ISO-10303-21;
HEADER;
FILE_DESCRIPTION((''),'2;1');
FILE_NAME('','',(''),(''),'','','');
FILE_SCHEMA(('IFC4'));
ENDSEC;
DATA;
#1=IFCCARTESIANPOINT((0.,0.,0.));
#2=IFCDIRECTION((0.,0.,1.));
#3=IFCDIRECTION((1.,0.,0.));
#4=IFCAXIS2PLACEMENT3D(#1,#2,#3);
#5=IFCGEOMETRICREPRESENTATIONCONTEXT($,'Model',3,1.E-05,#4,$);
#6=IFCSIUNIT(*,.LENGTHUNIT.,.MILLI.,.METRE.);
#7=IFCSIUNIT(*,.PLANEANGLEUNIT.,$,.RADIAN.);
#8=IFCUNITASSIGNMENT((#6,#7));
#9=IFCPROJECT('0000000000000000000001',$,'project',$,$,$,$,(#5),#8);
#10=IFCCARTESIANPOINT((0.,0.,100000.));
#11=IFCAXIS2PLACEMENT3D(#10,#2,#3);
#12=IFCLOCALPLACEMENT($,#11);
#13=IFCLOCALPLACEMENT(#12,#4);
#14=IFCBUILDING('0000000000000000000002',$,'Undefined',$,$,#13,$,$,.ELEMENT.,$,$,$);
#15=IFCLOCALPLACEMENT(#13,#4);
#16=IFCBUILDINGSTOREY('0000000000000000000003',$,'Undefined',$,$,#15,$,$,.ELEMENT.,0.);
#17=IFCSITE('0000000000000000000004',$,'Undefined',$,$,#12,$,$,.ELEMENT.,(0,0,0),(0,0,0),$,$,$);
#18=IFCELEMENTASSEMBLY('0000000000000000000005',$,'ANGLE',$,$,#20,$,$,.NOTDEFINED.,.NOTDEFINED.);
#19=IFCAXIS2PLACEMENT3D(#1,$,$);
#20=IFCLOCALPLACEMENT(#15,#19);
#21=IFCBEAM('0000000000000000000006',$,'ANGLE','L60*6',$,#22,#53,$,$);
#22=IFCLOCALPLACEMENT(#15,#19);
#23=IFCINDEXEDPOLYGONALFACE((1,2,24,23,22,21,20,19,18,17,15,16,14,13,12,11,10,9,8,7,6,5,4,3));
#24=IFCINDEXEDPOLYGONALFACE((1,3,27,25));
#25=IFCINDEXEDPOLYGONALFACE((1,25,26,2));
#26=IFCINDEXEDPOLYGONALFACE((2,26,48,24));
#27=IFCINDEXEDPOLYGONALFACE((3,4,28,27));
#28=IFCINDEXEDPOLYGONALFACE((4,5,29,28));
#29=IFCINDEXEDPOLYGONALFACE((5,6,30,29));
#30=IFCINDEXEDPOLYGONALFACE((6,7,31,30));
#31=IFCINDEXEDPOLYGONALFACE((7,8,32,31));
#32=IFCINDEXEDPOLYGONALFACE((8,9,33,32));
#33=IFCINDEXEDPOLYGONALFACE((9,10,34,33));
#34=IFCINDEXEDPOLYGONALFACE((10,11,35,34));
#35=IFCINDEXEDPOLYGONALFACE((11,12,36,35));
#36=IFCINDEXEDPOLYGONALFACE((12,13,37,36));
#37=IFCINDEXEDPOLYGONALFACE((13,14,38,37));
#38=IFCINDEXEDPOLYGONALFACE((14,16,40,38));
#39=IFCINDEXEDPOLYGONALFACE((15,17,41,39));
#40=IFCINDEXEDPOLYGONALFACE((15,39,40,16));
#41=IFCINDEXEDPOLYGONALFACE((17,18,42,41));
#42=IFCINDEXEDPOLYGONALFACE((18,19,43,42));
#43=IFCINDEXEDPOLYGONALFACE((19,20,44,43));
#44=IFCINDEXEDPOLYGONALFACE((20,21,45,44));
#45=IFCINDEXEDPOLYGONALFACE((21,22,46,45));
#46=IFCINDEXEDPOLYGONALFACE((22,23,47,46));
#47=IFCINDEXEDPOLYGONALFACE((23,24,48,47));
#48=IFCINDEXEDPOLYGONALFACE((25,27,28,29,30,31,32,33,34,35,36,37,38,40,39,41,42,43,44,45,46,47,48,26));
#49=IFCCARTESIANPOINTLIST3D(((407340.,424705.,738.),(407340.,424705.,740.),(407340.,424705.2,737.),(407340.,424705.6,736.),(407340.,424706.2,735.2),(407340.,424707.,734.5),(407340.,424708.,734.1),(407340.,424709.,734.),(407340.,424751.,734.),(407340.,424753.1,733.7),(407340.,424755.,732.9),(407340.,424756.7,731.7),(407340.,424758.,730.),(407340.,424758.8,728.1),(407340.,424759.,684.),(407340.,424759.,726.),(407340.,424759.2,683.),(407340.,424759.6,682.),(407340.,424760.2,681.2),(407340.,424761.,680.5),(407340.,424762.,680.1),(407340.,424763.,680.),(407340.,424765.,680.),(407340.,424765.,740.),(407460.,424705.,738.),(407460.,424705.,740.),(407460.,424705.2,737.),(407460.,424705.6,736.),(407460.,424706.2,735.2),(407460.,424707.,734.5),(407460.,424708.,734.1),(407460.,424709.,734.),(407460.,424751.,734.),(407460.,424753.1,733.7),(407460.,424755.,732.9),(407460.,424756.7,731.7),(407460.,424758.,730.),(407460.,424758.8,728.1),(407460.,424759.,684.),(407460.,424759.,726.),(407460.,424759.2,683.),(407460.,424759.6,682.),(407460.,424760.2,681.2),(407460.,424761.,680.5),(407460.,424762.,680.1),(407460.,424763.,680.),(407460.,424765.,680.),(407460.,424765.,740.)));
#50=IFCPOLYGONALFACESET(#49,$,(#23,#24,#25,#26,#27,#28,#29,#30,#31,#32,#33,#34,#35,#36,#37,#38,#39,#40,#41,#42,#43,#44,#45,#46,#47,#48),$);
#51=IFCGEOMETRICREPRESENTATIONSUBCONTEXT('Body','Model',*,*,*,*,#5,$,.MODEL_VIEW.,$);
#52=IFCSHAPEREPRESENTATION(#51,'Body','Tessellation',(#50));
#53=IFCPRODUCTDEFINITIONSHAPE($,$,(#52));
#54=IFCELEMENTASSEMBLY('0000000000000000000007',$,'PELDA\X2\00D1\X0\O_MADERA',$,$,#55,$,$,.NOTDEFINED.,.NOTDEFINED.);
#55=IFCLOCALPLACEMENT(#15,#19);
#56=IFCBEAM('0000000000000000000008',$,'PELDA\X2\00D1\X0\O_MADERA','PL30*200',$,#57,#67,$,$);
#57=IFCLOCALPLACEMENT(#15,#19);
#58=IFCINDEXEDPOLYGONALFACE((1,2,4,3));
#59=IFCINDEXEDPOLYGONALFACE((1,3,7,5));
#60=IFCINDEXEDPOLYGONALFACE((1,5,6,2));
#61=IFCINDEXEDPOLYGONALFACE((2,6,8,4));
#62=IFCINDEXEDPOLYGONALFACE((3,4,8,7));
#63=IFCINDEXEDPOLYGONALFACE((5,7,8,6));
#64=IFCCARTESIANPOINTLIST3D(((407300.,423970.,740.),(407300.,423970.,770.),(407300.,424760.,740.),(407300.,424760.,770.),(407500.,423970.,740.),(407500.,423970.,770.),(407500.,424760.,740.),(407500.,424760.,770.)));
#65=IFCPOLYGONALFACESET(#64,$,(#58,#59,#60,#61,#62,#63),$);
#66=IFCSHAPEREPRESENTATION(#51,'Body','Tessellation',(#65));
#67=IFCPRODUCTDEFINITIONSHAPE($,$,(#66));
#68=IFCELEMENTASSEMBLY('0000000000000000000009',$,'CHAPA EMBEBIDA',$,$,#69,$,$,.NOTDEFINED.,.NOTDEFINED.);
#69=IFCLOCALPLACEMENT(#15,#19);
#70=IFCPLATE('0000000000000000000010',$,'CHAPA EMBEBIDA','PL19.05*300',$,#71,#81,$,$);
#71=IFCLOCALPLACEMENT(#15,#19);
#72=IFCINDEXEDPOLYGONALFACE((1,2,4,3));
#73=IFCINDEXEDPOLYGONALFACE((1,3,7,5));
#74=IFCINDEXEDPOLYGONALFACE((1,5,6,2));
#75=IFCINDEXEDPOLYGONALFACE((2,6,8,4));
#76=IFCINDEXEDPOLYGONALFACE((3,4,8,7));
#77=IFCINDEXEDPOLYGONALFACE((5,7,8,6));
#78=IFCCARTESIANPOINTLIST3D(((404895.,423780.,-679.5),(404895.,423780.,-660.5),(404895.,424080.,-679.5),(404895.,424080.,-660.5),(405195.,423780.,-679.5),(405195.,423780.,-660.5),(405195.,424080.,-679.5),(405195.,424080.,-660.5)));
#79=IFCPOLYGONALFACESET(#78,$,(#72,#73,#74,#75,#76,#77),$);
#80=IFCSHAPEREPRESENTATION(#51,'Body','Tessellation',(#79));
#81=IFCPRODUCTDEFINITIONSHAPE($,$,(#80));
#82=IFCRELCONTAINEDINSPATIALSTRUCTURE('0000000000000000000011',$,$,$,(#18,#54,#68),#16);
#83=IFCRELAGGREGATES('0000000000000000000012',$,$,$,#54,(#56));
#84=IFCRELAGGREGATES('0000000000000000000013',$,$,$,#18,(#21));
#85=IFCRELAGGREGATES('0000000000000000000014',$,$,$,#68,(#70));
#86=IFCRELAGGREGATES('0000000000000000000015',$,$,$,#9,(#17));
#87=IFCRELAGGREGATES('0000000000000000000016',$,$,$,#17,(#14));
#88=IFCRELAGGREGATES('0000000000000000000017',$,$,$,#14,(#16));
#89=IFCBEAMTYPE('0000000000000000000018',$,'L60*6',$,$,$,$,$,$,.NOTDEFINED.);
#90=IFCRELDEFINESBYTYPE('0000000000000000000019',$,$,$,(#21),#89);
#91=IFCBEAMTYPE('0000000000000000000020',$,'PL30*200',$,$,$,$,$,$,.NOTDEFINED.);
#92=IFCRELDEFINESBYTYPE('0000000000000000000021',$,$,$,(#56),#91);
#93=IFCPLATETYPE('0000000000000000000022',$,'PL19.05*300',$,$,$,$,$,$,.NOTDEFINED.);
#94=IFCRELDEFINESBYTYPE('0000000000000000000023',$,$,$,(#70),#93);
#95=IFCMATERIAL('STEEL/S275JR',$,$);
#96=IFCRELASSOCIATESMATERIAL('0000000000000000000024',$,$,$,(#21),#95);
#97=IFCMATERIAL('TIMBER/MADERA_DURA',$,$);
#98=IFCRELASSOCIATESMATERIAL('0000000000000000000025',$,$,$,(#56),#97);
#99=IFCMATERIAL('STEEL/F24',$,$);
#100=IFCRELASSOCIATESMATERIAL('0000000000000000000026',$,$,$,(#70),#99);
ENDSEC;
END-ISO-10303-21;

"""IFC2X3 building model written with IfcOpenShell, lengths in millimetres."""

from ifc_helpers import new_model, si_unit, frame, origin_with_axes, origin_2d_with_axis, place, context, subcontext, project, spatial, polyline, rectangle, l_section, outline, extrude, material, type_object, element, aggregate, save


model = new_model("IFC2X3")

# Units and contexts
model_context = context("Model", 3, precision=1e-05, world=origin_with_axes())
body_context = subcontext(model_context, "Body", "Model", "MODEL_VIEW")
ifc_project = project(units=[si_unit("LENGTHUNIT", "METRE", prefix="MILLI"), si_unit("PLANEANGLEUNIT", "RADIAN")], contexts=[model_context])

# Site, building, storey
site_placement = place(None, frame((0.0, 0.0, 100000.0), z_axis=(0.0, 0.0, 1.0), x_axis=(1.0, 0.0, 0.0)))
site = spatial("IfcSite", under=ifc_project, at=site_placement, Name="Undefined", CompositionType="ELEMENT", RefLatitude=(0, 0, 0), RefLongitude=(0, 0, 0))
building_placement = place(site_placement, origin_with_axes())
building = spatial("IfcBuilding", under=site, at=building_placement, Name="Undefined", CompositionType="ELEMENT")
storey_placement = place(building_placement, origin_with_axes())
storey = spatial("IfcBuildingStorey", under=building, at=storey_placement, Name="Undefined", CompositionType="ELEMENT", Elevation=0.0)

# Shared definitions
ifc_material_1 = material(Name="STEEL/F24")

# Element assemblies, beams
ifc_material_2 = material(Name="STEEL/S275JR")
beam_type_1 = type_object("IfcBeamType", Name="L60*6", PredefinedType="NOTDEFINED")
assembly_1_placement = place(storey_placement, origin_with_axes())
assembly_1 = element("IfcElementAssembly", 1, at=assembly_1_placement, inside=storey, Name="ANGLE", AssemblyPlace="NOTDEFINED", PredefinedType="NOTDEFINED")
beam_1_placement = place(assembly_1_placement, frame((407340.0, 424735.0, 710.0), z_axis=(0.0, -1.0, 0.0), x_axis=(1.0, 0.0, 0.0)))
beam_1 = element("IfcBeam", 2, at=beam_1_placement, type_object=beam_type_1, material=ifc_material_2, Name="ANGLE", Description="L60*6", context=body_context, shape_type="SweptSolid", body=[
    extrude(l_section(Depth=60.0, Width=60.0, Thickness=6.0, FilletRadius=8.0, EdgeRadius=4.0, at=origin_2d_with_axis()), frame((120.0, 0.0, 0.0), z_axis=(-1.0, 0.0, 0.0), x_axis=(0.0, -1.0, 0.0)), (0.0, 0.0, 1.0), 120.0),
])
assembly_2_placement = place(storey_placement, origin_with_axes())
assembly_2 = element("IfcElementAssembly", 3, at=assembly_2_placement, inside=storey, Name="PELDAÑO_MADERA", AssemblyPlace="NOTDEFINED", PredefinedType="NOTDEFINED")
ifc_material_3 = material(Name="TIMBER/MADERA_DURA")
beam_type_2 = type_object("IfcBeamType", Name="PL30*200", PredefinedType="NOTDEFINED")
beam_2_placement = place(assembly_2_placement, frame((407400.0, 424760.0, 755.0), z_axis=(-1.0, 0.0, 0.0), x_axis=(0.0, -1.0, 0.0)))
beam_2 = element("IfcBeam", 4, at=beam_2_placement, type_object=beam_type_2, material=ifc_material_3, Name="PELDAÑO_MADERA", Description="PL30*200", context=body_context, shape_type="SweptSolid", body=[
    extrude(rectangle(XDim=30.0, YDim=200.0, at=origin_2d_with_axis()), frame((790.0, 0.0, 0.0), z_axis=(-1.0, 0.0, 0.0), x_axis=(0.0, -1.0, 0.0)), (0.0, 0.0, 1.0), 790.0),
])
aggregate(assembly_2, [beam_2])

# Element assembly, plate
assembly_3_placement = place(storey_placement, origin_with_axes())
assembly_3 = element("IfcElementAssembly", 5, at=assembly_3_placement, inside=storey, Name="CHAPA EMBEBIDA", AssemblyPlace="NOTDEFINED", PredefinedType="NOTDEFINED")
plate_type = type_object("IfcPlateType", Name="PL19.05*300", PredefinedType="NOTDEFINED")
plate_placement = place(assembly_3_placement, frame((404895.0, 423780.0, -670.0), z_axis=(0.0, 0.0, 1.0), x_axis=(1.0, 0.0, 0.0)))
plate = element("IfcPlate", 6, at=plate_placement, type_object=plate_type, material=ifc_material_1, Name="CHAPA EMBEBIDA", Description="PL19.05*300", context=body_context, shape_type="SweptSolid", body=[
    extrude(outline(polyline([(0.0, 0.0), (300.0, 0.0), (300.0, 300.0), (0.0, 300.0), (0.0, 0.0)])), frame((0.0, 0.0, -9.5), z_axis=(0.0, 0.0, 1.0), x_axis=(1.0, 0.0, 0.0)), (0.0, 0.0, 1.0), 19.1),
])

aggregate(assembly_1, [beam_1])

aggregate(assembly_3, [plate])

save(model, "model.ifc")
